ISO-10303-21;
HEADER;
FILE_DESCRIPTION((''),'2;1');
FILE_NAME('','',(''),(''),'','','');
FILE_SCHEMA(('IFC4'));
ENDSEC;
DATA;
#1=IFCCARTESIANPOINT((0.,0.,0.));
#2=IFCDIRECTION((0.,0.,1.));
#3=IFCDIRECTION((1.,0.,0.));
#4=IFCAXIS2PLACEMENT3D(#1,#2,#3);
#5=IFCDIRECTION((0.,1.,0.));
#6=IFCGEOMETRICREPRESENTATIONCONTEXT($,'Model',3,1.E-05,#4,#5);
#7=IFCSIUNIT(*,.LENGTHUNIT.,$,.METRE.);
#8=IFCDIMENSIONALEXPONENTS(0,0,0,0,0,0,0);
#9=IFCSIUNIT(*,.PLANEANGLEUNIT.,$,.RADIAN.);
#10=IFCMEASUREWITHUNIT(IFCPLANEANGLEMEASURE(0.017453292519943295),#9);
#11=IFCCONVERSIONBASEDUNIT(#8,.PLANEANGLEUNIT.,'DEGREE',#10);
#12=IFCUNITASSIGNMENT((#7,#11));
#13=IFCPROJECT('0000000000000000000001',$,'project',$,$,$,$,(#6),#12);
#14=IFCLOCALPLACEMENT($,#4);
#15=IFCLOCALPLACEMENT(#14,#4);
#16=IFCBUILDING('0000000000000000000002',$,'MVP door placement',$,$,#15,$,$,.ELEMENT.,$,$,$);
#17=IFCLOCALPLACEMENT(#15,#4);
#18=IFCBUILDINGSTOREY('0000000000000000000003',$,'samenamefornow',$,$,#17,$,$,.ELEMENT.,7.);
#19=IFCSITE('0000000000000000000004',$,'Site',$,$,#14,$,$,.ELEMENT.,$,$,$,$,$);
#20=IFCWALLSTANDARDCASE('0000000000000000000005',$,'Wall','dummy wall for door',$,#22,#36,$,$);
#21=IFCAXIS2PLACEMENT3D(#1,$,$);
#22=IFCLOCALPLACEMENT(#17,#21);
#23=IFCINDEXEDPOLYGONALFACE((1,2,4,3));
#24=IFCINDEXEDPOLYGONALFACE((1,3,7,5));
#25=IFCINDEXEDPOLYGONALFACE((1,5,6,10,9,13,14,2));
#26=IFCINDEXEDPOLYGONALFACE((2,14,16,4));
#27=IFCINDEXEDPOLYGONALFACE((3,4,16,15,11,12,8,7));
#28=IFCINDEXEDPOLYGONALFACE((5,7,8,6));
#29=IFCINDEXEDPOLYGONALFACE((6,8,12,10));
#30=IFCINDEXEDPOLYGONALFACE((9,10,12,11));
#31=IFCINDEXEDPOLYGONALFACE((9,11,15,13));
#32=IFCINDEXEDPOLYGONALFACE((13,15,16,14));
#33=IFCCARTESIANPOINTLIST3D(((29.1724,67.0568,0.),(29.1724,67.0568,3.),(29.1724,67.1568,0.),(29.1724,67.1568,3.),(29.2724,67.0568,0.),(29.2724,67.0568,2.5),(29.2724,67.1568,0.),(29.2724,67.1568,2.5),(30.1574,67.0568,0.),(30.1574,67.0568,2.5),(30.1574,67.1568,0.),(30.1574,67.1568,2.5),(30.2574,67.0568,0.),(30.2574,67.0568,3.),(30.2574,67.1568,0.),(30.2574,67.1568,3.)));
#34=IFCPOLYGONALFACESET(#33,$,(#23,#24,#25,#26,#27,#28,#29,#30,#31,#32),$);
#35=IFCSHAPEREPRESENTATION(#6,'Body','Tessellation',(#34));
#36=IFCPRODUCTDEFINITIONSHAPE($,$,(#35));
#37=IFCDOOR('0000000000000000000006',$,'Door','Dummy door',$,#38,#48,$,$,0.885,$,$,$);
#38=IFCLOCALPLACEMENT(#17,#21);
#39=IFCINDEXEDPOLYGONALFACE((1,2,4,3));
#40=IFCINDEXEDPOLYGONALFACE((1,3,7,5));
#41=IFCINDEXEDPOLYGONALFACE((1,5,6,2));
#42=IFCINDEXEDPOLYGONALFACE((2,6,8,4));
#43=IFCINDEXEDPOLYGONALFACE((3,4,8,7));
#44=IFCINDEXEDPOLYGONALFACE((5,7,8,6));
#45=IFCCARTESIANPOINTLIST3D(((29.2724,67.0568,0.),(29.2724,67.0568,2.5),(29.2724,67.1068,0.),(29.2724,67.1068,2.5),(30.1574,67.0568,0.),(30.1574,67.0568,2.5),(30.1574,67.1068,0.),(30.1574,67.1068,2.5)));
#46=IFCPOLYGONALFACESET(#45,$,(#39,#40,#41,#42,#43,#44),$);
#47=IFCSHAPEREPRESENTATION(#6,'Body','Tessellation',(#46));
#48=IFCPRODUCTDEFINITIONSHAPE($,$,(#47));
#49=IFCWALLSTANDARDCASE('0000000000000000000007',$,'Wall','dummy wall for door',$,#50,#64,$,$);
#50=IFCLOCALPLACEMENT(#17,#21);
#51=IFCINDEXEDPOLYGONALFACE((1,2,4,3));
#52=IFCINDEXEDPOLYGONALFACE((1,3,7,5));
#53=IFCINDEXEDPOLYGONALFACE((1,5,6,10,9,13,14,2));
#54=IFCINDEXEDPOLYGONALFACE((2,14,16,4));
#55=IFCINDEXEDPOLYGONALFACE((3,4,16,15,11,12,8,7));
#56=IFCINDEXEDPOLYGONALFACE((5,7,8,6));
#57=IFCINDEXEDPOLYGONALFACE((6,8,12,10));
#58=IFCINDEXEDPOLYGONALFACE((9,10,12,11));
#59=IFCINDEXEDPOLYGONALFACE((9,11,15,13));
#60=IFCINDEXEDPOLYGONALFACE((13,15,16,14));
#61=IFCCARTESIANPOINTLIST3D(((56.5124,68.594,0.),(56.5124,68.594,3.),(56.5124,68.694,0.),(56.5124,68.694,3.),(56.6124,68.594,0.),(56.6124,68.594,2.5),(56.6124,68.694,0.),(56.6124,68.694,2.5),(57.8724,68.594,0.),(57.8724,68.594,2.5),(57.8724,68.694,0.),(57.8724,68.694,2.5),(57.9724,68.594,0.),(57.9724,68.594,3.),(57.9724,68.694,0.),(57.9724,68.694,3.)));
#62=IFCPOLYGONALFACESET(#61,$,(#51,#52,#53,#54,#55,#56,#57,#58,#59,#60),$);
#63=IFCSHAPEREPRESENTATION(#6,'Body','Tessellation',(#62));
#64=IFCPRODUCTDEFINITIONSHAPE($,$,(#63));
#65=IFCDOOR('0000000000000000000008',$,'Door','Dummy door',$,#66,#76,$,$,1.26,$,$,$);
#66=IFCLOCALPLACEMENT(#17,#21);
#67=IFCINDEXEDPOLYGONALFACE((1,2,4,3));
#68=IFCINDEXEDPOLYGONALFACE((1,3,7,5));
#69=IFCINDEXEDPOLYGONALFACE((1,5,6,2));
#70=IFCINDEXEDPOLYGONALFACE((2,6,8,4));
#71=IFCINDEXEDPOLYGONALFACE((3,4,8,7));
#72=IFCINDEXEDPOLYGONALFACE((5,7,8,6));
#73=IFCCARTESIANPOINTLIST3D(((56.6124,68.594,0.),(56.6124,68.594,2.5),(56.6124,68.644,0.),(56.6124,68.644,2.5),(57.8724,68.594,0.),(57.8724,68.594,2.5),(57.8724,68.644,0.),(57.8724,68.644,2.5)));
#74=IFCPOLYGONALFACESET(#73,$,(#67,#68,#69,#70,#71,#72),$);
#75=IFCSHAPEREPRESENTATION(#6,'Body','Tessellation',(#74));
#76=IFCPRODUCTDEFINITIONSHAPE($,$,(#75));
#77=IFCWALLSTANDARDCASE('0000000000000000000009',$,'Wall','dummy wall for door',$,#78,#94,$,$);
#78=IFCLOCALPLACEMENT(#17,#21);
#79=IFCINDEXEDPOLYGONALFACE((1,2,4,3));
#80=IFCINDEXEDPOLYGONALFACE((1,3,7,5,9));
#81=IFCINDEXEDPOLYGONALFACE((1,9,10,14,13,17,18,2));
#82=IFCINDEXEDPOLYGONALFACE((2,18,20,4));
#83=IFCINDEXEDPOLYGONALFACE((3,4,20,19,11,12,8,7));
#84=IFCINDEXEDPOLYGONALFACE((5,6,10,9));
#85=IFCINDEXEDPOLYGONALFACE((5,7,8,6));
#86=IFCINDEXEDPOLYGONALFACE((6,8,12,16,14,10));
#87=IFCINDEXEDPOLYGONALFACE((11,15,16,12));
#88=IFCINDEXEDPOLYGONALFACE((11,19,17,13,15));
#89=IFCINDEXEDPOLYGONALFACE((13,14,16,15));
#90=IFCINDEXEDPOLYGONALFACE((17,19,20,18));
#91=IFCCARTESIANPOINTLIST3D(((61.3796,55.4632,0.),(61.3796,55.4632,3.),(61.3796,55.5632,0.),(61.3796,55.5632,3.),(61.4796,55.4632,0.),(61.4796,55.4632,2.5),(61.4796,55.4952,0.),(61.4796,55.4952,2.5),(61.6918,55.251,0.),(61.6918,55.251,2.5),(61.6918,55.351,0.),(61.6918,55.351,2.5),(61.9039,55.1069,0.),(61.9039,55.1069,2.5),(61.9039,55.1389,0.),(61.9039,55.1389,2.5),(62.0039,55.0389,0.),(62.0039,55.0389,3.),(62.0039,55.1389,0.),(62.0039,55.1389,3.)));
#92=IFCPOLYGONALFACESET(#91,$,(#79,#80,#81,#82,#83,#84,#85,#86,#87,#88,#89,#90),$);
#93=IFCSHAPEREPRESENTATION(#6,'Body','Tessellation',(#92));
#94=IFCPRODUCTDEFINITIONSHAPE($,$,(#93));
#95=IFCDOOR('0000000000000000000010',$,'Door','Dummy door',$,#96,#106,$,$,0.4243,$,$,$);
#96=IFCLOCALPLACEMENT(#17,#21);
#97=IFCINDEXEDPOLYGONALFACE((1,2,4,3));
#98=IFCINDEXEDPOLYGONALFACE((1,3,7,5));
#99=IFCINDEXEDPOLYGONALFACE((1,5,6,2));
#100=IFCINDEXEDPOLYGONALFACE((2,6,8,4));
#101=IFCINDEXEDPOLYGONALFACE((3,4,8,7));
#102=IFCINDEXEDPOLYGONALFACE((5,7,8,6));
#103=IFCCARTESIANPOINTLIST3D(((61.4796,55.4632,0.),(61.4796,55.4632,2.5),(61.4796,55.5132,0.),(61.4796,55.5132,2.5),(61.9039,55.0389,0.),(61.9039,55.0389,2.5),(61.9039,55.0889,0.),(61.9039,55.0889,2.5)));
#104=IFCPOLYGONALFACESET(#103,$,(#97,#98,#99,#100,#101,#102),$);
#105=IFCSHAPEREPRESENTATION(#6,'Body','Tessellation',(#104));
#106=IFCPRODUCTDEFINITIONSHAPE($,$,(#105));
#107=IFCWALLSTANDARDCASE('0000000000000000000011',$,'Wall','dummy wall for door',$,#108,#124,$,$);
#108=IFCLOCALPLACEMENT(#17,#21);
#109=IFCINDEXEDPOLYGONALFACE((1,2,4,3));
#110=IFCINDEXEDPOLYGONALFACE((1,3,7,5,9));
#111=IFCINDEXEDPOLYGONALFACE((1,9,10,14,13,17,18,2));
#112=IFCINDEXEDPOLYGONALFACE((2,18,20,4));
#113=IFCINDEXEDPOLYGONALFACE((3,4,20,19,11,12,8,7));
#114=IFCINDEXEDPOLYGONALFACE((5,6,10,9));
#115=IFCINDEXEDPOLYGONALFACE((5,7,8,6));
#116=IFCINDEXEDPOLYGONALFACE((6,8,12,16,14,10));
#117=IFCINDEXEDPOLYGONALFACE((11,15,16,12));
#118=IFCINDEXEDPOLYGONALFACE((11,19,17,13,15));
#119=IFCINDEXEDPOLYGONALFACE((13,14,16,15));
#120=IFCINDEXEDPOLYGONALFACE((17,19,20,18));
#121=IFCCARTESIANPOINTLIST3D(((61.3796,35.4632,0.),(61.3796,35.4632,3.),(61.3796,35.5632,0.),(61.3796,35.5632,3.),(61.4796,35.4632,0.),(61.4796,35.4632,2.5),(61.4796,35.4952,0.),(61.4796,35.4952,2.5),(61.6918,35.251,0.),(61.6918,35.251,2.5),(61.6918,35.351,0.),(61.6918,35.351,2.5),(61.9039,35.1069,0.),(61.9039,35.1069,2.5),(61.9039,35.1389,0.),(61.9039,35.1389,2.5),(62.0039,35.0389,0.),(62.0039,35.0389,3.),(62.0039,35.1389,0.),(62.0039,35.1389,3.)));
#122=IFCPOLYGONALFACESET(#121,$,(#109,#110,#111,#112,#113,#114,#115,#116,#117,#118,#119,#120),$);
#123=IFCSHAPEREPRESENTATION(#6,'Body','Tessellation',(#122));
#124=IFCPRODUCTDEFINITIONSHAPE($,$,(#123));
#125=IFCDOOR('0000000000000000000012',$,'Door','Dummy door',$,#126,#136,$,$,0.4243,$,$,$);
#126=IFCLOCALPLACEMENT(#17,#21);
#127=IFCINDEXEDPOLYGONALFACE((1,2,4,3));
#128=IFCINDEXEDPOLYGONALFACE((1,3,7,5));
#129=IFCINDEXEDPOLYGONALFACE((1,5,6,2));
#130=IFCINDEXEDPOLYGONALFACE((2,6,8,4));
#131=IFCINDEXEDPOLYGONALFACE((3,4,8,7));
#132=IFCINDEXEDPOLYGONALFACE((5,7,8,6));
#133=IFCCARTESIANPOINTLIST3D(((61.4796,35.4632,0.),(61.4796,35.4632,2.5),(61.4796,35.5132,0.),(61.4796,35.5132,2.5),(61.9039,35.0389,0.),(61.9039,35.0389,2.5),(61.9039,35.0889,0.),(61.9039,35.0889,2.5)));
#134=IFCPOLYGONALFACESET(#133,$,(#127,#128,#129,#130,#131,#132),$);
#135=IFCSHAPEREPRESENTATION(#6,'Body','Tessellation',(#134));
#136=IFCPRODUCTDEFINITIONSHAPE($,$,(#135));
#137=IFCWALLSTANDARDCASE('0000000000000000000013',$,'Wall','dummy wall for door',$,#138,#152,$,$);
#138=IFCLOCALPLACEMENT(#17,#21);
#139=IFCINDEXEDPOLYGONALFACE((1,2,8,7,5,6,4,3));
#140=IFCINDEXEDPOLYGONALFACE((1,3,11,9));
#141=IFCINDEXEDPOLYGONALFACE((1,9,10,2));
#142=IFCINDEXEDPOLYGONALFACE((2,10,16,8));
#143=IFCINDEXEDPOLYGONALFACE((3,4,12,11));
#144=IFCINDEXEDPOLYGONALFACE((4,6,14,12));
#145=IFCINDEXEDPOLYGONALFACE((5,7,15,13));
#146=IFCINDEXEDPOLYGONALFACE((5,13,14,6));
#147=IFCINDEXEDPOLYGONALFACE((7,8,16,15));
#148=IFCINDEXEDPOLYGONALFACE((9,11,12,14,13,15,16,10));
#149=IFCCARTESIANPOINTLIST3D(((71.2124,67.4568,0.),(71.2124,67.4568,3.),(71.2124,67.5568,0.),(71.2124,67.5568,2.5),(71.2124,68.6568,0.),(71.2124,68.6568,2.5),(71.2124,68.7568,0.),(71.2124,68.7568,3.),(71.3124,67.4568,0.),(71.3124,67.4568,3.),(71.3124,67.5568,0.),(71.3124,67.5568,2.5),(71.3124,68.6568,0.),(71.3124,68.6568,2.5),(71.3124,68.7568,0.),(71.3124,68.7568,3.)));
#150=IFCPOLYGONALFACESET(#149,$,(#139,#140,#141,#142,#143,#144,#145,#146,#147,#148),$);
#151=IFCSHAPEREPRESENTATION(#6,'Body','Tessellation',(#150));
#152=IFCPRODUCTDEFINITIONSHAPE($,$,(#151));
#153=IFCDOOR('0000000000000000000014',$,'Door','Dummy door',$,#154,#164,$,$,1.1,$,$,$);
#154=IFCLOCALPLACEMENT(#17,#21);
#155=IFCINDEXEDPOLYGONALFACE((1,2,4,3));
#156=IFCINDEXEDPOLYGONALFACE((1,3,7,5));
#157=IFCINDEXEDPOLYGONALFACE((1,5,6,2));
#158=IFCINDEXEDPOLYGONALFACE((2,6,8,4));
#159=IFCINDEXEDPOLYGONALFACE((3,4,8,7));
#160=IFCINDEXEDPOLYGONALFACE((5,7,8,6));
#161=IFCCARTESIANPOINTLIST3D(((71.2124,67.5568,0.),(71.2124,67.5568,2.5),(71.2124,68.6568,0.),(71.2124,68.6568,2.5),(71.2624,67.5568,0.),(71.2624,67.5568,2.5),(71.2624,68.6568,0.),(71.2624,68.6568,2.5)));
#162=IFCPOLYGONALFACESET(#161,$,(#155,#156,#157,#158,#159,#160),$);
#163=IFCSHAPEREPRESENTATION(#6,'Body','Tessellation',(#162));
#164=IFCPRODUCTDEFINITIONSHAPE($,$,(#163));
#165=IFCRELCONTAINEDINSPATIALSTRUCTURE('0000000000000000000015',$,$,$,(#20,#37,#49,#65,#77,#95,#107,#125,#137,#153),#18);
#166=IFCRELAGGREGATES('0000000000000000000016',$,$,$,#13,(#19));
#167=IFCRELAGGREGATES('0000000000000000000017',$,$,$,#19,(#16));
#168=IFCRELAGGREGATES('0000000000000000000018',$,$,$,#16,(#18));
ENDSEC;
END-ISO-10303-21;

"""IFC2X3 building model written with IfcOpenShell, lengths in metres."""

from ifc_helpers import new_model, entity, si_unit, converted_unit, direction, origin_with_axes, place, context, project, spatial, polyline, outline, extrude, element, fill, save


model = new_model("IFC2X3")

# Units and contexts
model_context = context("Model", 3, precision=1e-05, world=origin_with_axes(), true_north=direction((0.0, 1.0, 0.0)))
ifc_project = project(units=[si_unit("LENGTHUNIT", "METRE"), converted_unit("PLANEANGLEUNIT", "DEGREE", entity("IfcPlaneAngleMeasure", 0.017453292519943295), si_unit("PLANEANGLEUNIT", "RADIAN"), dimensions=[0, 0, 0, 0, 0, 0, 0])], contexts=[model_context])

# Site, building, storey
site_placement = place(None, origin_with_axes())
site = spatial("IfcSite", under=ifc_project, at=site_placement, Name="Site", CompositionType="ELEMENT")
building_placement = place(site_placement, origin_with_axes())
building = spatial("IfcBuilding", under=site, at=building_placement, Name="MVP door placement", CompositionType="ELEMENT")
storey_placement = place(building_placement, origin_with_axes())
storey = spatial("IfcBuildingStorey", under=building, at=storey_placement, Name="samenamefornow", CompositionType="ELEMENT", Elevation=7.0)

# Walls, openings, doors
wall_1_placement = place(storey_placement, origin_with_axes())
wall_1 = element("IfcWallStandardCase", 1, at=wall_1_placement, inside=storey, Name="Wall", Description="dummy wall for door", context=model_context, shape_type="SweptSolid", body=[
    extrude(outline(polyline([(30.2574, 67.0568, 0.0), (29.1724, 67.0568, 0.0), (29.1724, 67.1568, 0.0), (30.2574, 67.1568, 0.0), (30.2574, 67.0568, 0.0)])), origin_with_axes(), (0.0, 0.0, 1.0), 3.0),
])
opening_1_placement = place(wall_1_placement, origin_with_axes())
opening_1 = element("IfcOpeningElement", 2, at=opening_1_placement, cuts=wall_1, context=model_context, shape_type="SweptSolid", body=[
    extrude(outline(polyline([(30.1574, 67.0568, 0.0), (29.2724, 67.0568, 0.0), (29.2724, 67.1568, 0.0), (30.1574, 67.1568, 0.0), (30.1574, 67.0568, 0.0)])), origin_with_axes(), (0.0, 0.0, 1.0), 2.5),
])
door_1_placement = place(opening_1_placement, origin_with_axes())
door_1 = element("IfcDoor", 3, at=door_1_placement, inside=storey, Name="Door", Description="Dummy door", OverallWidth=0.885, context=model_context, shape_type="SweptSolid", body=[
    extrude(outline(polyline([(30.1574, 67.0568, 0.0), (29.2724, 67.0568, 0.0), (29.2724, 67.1068, 0.0), (30.1574, 67.1068, 0.0), (30.1574, 67.0568, 0.0)])), origin_with_axes(), (0.0, 0.0, 1.0), 2.5),
])
fill(opening_1, door_1)
wall_2_placement = place(storey_placement, origin_with_axes())
wall_2 = element("IfcWallStandardCase", 4, at=wall_2_placement, inside=storey, Name="Wall", Description="dummy wall for door", context=model_context, shape_type="SweptSolid", body=[
    extrude(outline(polyline([(56.5124, 68.594, 0.0), (57.9724, 68.594, 0.0), (57.9724, 68.694, 0.0), (56.5124, 68.694, 0.0), (56.5124, 68.594, 0.0)])), origin_with_axes(), (0.0, 0.0, 1.0), 3.0),
])
opening_2_placement = place(wall_2_placement, origin_with_axes())
opening_2 = element("IfcOpeningElement", 5, at=opening_2_placement, cuts=wall_2, context=model_context, shape_type="SweptSolid", body=[
    extrude(outline(polyline([(56.6124, 68.594, 0.0), (57.8724, 68.594, 0.0), (57.8724, 68.694, 0.0), (56.6124, 68.694, 0.0), (56.6124, 68.594, 0.0)])), origin_with_axes(), (0.0, 0.0, 1.0), 2.5),
])
door_2_placement = place(opening_2_placement, origin_with_axes())
door_2 = element("IfcDoor", 6, at=door_2_placement, inside=storey, Name="Door", Description="Dummy door", OverallWidth=1.26, context=model_context, shape_type="SweptSolid", body=[
    extrude(outline(polyline([(56.6124, 68.594, 0.0), (57.8724, 68.594, 0.0), (57.8724, 68.644, 0.0), (56.6124, 68.644, 0.0), (56.6124, 68.594, 0.0)])), origin_with_axes(), (0.0, 0.0, 1.0), 2.5),
])
fill(opening_2, door_2)
wall_3_placement = place(storey_placement, origin_with_axes())
wall_3 = element("IfcWallStandardCase", 7, at=wall_3_placement, inside=storey, Name="Wall", Description="dummy wall for door", context=model_context, shape_type="SweptSolid", body=[
    extrude(outline(polyline([(61.3796, 55.4632, 0.0), (62.0039, 55.0389, 0.0), (62.0039, 55.1389, 0.0), (61.3796, 55.5632, 0.0), (61.3796, 55.4632, 0.0)])), origin_with_axes(), (0.0, 0.0, 1.0), 3.0),
])
opening_3_placement = place(wall_3_placement, origin_with_axes())
opening_3 = element("IfcOpeningElement", 8, at=opening_3_placement, cuts=wall_3, context=model_context, shape_type="SweptSolid", body=[
    extrude(outline(polyline([(61.4796, 55.4632, 0.0), (61.9039, 55.0389, 0.0), (61.9039, 55.1389, 0.0), (61.4796, 55.5632, 0.0), (61.4796, 55.4632, 0.0)])), origin_with_axes(), (0.0, 0.0, 1.0), 2.5),
])
door_3_placement = place(opening_3_placement, origin_with_axes())
door_3 = element("IfcDoor", 9, at=door_3_placement, inside=storey, Name="Door", Description="Dummy door", OverallWidth=0.4243, context=model_context, shape_type="SweptSolid", body=[
    extrude(outline(polyline([(61.4796, 55.4632, 0.0), (61.9039, 55.0389, 0.0), (61.9039, 55.0889, 0.0), (61.4796, 55.5132, 0.0), (61.4796, 55.4632, 0.0)])), origin_with_axes(), (0.0, 0.0, 1.0), 2.5),
])
fill(opening_3, door_3)
wall_4_placement = place(storey_placement, origin_with_axes())
wall_4 = element("IfcWallStandardCase", 10, at=wall_4_placement, inside=storey, Name="Wall", Description="dummy wall for door", context=model_context, shape_type="SweptSolid", body=[
    extrude(outline(polyline([(61.3796, 35.4632, 0.0), (62.0039, 35.0389, 0.0), (62.0039, 35.1389, 0.0), (61.3796, 35.5632, 0.0), (61.3796, 35.4632, 0.0)])), origin_with_axes(), (0.0, 0.0, 1.0), 3.0),
])
opening_4_placement = place(wall_4_placement, origin_with_axes())
opening_4 = element("IfcOpeningElement", 11, at=opening_4_placement, cuts=wall_4, context=model_context, shape_type="SweptSolid", body=[
    extrude(outline(polyline([(61.4796, 35.4632, 0.0), (61.9039, 35.0389, 0.0), (61.9039, 35.1389, 0.0), (61.4796, 35.5632, 0.0), (61.4796, 35.4632, 0.0)])), origin_with_axes(), (0.0, 0.0, 1.0), 2.5),
])
door_4_placement = place(opening_4_placement, origin_with_axes())
door_4 = element("IfcDoor", 12, at=door_4_placement, inside=storey, Name="Door", Description="Dummy door", OverallWidth=0.4243, context=model_context, shape_type="SweptSolid", body=[
    extrude(outline(polyline([(61.4796, 35.4632, 0.0), (61.9039, 35.0389, 0.0), (61.9039, 35.0889, 0.0), (61.4796, 35.5132, 0.0), (61.4796, 35.4632, 0.0)])), origin_with_axes(), (0.0, 0.0, 1.0), 2.5),
])
fill(opening_4, door_4)
wall_5_placement = place(storey_placement, origin_with_axes())
wall_5 = element("IfcWallStandardCase", 13, at=wall_5_placement, inside=storey, Name="Wall", Description="dummy wall for door", context=model_context, shape_type="SweptSolid", body=[
    extrude(outline(polyline([(71.2124, 67.4568, 0.0), (71.2124, 68.7568, 0.0), (71.3124, 68.7568, 0.0), (71.3124, 67.4568, 0.0), (71.2124, 67.4568, 0.0)])), origin_with_axes(), (0.0, 0.0, 1.0), 3.0),
])
opening_5_placement = place(wall_5_placement, origin_with_axes())
opening_5 = element("IfcOpeningElement", 14, at=opening_5_placement, cuts=wall_5, context=model_context, shape_type="SweptSolid", body=[
    extrude(outline(polyline([(71.2124, 67.5568, 0.0), (71.2124, 68.6568, 0.0), (71.3124, 68.6568, 0.0), (71.3124, 67.5568, 0.0), (71.2124, 67.5568, 0.0)])), origin_with_axes(), (0.0, 0.0, 1.0), 2.5),
])
door_5_placement = place(opening_5_placement, origin_with_axes())
door_5 = element("IfcDoor", 15, at=door_5_placement, inside=storey, Name="Door", Description="Dummy door", OverallWidth=1.1, context=model_context, shape_type="SweptSolid", body=[
    extrude(outline(polyline([(71.2124, 67.5568, 0.0), (71.2124, 68.6568, 0.0), (71.2624, 68.6568, 0.0), (71.2624, 67.5568, 0.0), (71.2124, 67.5568, 0.0)])), origin_with_axes(), (0.0, 0.0, 1.0), 2.5),
])
fill(opening_5, door_5)

save(model, "model.ifc")
